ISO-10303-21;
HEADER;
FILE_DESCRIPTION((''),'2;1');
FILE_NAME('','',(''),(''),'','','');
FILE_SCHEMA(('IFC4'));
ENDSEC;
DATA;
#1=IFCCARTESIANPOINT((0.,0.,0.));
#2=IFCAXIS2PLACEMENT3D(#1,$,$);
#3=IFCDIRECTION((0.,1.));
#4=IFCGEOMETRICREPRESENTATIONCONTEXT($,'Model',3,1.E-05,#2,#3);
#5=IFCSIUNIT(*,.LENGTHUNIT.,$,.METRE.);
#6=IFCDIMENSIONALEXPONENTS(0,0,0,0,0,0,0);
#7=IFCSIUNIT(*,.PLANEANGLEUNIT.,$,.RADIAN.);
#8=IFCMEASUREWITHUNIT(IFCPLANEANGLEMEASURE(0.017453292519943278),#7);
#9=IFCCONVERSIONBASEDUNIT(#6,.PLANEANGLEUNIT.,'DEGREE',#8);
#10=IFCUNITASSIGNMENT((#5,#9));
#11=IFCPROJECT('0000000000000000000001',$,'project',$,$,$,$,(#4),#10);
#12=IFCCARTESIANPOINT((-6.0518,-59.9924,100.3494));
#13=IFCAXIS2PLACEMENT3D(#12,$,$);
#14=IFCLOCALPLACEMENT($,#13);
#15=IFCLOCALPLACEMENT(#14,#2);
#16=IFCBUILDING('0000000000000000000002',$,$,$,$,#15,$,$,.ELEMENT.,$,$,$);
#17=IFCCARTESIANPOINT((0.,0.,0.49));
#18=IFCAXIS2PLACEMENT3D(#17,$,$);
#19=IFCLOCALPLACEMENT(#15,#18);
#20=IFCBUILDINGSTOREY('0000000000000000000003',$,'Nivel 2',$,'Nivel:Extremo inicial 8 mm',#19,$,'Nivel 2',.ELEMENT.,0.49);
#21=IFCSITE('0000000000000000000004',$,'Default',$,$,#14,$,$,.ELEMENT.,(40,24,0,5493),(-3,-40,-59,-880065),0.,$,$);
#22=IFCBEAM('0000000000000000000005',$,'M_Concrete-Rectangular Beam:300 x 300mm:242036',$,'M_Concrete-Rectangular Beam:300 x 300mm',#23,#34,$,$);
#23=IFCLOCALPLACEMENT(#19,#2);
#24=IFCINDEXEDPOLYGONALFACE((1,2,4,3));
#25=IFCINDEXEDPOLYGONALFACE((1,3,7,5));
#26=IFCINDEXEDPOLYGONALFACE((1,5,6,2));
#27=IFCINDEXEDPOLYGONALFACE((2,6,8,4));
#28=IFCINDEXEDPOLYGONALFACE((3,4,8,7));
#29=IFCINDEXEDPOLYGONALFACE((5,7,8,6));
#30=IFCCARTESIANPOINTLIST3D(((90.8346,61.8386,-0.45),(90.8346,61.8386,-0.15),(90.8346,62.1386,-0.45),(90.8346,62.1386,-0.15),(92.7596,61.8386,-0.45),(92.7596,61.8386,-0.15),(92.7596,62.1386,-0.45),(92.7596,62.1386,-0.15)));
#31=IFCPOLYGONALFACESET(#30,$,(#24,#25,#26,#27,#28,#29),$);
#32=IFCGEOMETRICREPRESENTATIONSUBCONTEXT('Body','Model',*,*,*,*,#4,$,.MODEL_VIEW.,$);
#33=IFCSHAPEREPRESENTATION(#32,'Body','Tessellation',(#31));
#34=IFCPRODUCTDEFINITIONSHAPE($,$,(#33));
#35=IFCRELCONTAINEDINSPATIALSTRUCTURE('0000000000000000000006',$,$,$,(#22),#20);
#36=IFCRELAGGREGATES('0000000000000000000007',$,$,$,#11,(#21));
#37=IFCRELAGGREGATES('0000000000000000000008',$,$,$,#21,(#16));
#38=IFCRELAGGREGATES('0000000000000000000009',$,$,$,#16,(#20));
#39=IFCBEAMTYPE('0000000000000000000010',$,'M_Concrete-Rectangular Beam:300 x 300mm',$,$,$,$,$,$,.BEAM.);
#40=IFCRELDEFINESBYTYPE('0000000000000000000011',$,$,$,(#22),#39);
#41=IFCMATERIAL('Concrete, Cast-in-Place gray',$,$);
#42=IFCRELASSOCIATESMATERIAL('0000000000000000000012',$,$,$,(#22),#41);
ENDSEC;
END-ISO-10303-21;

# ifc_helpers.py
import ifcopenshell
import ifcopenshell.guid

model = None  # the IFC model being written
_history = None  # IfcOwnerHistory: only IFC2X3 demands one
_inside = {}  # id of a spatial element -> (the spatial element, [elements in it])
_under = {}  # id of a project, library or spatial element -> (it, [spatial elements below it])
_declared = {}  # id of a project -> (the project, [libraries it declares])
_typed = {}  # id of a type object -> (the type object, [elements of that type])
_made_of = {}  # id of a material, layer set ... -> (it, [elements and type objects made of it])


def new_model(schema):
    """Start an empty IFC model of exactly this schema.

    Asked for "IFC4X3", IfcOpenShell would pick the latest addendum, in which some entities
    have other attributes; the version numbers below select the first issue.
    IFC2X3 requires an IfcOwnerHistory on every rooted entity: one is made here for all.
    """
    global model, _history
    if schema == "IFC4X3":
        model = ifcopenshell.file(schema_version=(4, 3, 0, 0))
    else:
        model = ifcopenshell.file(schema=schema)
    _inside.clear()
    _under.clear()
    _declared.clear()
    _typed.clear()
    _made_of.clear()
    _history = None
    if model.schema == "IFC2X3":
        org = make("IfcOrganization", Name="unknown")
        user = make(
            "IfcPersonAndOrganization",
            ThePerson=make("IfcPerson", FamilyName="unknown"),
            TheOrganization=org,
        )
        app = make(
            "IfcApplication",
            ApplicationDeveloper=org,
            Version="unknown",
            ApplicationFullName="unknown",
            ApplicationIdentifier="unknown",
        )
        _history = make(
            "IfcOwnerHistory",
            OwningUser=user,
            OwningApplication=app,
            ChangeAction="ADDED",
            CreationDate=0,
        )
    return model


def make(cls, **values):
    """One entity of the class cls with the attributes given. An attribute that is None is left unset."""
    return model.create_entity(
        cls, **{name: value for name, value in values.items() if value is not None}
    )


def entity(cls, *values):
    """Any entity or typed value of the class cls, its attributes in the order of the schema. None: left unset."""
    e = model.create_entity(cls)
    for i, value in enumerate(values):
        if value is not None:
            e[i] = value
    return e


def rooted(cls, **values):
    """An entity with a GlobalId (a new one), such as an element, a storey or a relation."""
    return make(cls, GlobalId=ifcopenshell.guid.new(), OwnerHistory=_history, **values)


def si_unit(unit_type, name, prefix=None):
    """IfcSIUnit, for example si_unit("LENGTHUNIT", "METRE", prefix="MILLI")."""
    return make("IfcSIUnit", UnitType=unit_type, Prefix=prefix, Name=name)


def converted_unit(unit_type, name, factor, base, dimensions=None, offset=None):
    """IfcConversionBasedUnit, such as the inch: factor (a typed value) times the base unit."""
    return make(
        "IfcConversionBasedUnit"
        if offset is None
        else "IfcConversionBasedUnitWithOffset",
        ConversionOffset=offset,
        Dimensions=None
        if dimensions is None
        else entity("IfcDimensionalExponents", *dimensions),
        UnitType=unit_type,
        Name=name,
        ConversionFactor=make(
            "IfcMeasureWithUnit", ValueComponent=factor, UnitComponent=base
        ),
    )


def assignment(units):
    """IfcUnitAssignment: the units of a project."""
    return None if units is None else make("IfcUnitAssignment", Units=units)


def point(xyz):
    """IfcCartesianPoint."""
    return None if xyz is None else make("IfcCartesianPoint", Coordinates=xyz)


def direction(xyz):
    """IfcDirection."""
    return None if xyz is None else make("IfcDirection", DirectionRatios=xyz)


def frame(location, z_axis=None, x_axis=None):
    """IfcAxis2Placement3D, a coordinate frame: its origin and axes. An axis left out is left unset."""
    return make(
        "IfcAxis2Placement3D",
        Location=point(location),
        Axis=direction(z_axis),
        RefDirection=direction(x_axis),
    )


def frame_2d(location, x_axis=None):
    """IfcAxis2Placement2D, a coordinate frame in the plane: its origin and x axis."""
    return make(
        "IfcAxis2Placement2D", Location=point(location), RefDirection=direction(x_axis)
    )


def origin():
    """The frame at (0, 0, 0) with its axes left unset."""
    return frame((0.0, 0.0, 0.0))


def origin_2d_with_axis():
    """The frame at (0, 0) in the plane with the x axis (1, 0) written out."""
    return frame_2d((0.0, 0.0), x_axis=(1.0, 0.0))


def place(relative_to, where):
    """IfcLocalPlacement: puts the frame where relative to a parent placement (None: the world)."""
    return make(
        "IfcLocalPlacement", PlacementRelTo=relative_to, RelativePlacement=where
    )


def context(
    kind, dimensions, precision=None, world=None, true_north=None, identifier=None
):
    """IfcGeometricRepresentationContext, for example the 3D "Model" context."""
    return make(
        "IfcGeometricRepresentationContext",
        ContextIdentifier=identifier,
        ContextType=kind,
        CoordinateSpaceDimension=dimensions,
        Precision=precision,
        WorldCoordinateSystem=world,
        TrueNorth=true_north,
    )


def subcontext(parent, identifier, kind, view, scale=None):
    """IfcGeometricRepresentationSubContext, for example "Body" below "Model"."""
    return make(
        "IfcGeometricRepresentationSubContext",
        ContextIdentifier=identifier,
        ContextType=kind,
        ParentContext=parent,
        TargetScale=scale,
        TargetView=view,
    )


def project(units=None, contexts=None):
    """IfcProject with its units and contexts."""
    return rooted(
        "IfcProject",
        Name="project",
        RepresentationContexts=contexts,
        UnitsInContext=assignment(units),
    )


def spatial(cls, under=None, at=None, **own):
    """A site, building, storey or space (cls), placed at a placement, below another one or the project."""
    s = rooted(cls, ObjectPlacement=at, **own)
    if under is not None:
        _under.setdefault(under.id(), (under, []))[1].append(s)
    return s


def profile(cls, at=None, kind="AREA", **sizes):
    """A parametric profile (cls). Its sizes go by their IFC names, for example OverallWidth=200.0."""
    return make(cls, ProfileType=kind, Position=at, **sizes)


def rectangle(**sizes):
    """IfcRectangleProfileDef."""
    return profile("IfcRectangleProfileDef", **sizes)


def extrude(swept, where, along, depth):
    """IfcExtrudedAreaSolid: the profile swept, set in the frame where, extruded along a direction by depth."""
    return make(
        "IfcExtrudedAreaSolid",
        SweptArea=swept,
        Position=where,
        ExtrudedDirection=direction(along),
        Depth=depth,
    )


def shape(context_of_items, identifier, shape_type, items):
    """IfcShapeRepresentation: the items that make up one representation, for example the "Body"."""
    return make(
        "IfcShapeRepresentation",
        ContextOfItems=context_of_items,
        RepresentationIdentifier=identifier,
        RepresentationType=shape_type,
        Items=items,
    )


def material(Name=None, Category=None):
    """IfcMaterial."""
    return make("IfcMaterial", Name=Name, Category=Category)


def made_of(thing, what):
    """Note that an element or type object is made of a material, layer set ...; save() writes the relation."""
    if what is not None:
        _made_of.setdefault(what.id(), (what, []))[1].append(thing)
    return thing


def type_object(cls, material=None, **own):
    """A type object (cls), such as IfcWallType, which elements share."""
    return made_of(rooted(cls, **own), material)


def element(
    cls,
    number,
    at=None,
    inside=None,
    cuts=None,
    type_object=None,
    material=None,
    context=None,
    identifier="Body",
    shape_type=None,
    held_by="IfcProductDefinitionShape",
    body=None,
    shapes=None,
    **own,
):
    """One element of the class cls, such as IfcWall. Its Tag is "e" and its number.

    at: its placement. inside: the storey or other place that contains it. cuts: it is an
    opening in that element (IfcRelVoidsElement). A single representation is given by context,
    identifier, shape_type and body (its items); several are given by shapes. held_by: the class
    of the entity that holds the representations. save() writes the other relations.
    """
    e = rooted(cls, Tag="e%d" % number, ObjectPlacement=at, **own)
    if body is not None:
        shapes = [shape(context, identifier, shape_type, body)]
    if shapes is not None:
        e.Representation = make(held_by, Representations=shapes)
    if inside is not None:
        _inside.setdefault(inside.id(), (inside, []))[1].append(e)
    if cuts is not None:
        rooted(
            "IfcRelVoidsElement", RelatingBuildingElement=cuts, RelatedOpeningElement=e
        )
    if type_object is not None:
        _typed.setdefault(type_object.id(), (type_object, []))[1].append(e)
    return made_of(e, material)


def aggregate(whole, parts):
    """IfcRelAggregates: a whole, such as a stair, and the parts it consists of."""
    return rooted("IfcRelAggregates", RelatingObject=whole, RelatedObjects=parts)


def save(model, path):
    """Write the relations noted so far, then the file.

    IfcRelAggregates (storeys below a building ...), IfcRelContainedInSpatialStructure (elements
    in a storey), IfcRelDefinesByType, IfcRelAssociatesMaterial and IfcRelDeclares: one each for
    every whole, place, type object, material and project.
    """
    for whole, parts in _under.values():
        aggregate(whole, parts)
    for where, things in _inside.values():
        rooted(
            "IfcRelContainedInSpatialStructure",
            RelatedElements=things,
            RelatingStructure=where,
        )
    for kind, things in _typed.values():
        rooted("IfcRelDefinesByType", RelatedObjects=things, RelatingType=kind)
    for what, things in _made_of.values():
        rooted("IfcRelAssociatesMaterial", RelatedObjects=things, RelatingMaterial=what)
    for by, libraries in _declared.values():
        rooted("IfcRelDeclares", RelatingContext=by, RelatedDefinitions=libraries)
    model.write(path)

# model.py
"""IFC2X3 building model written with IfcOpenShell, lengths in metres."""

from ifc_helpers import new_model, entity, si_unit, converted_unit, direction, frame, origin, origin_2d_with_axis, place, context, subcontext, project, spatial, rectangle, extrude, material, type_object, element, save


model = new_model("IFC2X3")

# Units and contexts
model_context = context("Model", 3, precision=1e-05, world=origin(), true_north=direction((0.0, 1.0)))
body_context = subcontext(model_context, "Body", "Model", "MODEL_VIEW")
ifc_project = project(units=[si_unit("LENGTHUNIT", "METRE"), converted_unit("PLANEANGLEUNIT", "DEGREE", entity("IfcPlaneAngleMeasure", 0.017453292519943278), si_unit("PLANEANGLEUNIT", "RADIAN"), dimensions=[0, 0, 0, 0, 0, 0, 0])], contexts=[model_context])

# Site, building, storey
site_placement = place(None, frame((-6.0518, -59.9924, 100.3494)))
site = spatial("IfcSite", under=ifc_project, at=site_placement, Name="Default", CompositionType="ELEMENT", RefLatitude=(40, 24, 0, 5493), RefLongitude=(-3, -40, -59, -880065), RefElevation=0.0)
building_placement = place(site_placement, origin())
building = spatial("IfcBuilding", under=site, at=building_placement, CompositionType="ELEMENT")
storey_placement = place(building_placement, frame((0.0, 0.0, 0.49)))
storey = spatial("IfcBuildingStorey", under=building, at=storey_placement, Name="Nivel 2", ObjectType="Nivel:Extremo inicial 8 mm", LongName="Nivel 2", CompositionType="ELEMENT", Elevation=0.49)

# Beam
ifc_material_1 = material(Name="Concrete, Cast-in-Place gray")
beam_type = type_object("IfcBeamType", Name="M_Concrete-Rectangular Beam:300 x 300mm", PredefinedType="BEAM")
beam_placement = place(storey_placement, frame((90.6846, 61.9886, 0.0)))
element("IfcBeam", 1, at=beam_placement, inside=storey, type_object=beam_type, material=ifc_material_1, Name="M_Concrete-Rectangular Beam:300 x 300mm:242036", ObjectType="M_Concrete-Rectangular Beam:300 x 300mm", context=body_context, shape_type="SweptSolid", body=[
    extrude(rectangle(XDim=0.3, YDim=0.3, at=origin_2d_with_axis()), frame((0.15, 0.0, -0.3), z_axis=(1.0, 0.0, 0.0), x_axis=(0.0, 0.0, -1.0)), (0.0, 0.0, 1.0), 1.925),
])

save(model, "model.ifc")
